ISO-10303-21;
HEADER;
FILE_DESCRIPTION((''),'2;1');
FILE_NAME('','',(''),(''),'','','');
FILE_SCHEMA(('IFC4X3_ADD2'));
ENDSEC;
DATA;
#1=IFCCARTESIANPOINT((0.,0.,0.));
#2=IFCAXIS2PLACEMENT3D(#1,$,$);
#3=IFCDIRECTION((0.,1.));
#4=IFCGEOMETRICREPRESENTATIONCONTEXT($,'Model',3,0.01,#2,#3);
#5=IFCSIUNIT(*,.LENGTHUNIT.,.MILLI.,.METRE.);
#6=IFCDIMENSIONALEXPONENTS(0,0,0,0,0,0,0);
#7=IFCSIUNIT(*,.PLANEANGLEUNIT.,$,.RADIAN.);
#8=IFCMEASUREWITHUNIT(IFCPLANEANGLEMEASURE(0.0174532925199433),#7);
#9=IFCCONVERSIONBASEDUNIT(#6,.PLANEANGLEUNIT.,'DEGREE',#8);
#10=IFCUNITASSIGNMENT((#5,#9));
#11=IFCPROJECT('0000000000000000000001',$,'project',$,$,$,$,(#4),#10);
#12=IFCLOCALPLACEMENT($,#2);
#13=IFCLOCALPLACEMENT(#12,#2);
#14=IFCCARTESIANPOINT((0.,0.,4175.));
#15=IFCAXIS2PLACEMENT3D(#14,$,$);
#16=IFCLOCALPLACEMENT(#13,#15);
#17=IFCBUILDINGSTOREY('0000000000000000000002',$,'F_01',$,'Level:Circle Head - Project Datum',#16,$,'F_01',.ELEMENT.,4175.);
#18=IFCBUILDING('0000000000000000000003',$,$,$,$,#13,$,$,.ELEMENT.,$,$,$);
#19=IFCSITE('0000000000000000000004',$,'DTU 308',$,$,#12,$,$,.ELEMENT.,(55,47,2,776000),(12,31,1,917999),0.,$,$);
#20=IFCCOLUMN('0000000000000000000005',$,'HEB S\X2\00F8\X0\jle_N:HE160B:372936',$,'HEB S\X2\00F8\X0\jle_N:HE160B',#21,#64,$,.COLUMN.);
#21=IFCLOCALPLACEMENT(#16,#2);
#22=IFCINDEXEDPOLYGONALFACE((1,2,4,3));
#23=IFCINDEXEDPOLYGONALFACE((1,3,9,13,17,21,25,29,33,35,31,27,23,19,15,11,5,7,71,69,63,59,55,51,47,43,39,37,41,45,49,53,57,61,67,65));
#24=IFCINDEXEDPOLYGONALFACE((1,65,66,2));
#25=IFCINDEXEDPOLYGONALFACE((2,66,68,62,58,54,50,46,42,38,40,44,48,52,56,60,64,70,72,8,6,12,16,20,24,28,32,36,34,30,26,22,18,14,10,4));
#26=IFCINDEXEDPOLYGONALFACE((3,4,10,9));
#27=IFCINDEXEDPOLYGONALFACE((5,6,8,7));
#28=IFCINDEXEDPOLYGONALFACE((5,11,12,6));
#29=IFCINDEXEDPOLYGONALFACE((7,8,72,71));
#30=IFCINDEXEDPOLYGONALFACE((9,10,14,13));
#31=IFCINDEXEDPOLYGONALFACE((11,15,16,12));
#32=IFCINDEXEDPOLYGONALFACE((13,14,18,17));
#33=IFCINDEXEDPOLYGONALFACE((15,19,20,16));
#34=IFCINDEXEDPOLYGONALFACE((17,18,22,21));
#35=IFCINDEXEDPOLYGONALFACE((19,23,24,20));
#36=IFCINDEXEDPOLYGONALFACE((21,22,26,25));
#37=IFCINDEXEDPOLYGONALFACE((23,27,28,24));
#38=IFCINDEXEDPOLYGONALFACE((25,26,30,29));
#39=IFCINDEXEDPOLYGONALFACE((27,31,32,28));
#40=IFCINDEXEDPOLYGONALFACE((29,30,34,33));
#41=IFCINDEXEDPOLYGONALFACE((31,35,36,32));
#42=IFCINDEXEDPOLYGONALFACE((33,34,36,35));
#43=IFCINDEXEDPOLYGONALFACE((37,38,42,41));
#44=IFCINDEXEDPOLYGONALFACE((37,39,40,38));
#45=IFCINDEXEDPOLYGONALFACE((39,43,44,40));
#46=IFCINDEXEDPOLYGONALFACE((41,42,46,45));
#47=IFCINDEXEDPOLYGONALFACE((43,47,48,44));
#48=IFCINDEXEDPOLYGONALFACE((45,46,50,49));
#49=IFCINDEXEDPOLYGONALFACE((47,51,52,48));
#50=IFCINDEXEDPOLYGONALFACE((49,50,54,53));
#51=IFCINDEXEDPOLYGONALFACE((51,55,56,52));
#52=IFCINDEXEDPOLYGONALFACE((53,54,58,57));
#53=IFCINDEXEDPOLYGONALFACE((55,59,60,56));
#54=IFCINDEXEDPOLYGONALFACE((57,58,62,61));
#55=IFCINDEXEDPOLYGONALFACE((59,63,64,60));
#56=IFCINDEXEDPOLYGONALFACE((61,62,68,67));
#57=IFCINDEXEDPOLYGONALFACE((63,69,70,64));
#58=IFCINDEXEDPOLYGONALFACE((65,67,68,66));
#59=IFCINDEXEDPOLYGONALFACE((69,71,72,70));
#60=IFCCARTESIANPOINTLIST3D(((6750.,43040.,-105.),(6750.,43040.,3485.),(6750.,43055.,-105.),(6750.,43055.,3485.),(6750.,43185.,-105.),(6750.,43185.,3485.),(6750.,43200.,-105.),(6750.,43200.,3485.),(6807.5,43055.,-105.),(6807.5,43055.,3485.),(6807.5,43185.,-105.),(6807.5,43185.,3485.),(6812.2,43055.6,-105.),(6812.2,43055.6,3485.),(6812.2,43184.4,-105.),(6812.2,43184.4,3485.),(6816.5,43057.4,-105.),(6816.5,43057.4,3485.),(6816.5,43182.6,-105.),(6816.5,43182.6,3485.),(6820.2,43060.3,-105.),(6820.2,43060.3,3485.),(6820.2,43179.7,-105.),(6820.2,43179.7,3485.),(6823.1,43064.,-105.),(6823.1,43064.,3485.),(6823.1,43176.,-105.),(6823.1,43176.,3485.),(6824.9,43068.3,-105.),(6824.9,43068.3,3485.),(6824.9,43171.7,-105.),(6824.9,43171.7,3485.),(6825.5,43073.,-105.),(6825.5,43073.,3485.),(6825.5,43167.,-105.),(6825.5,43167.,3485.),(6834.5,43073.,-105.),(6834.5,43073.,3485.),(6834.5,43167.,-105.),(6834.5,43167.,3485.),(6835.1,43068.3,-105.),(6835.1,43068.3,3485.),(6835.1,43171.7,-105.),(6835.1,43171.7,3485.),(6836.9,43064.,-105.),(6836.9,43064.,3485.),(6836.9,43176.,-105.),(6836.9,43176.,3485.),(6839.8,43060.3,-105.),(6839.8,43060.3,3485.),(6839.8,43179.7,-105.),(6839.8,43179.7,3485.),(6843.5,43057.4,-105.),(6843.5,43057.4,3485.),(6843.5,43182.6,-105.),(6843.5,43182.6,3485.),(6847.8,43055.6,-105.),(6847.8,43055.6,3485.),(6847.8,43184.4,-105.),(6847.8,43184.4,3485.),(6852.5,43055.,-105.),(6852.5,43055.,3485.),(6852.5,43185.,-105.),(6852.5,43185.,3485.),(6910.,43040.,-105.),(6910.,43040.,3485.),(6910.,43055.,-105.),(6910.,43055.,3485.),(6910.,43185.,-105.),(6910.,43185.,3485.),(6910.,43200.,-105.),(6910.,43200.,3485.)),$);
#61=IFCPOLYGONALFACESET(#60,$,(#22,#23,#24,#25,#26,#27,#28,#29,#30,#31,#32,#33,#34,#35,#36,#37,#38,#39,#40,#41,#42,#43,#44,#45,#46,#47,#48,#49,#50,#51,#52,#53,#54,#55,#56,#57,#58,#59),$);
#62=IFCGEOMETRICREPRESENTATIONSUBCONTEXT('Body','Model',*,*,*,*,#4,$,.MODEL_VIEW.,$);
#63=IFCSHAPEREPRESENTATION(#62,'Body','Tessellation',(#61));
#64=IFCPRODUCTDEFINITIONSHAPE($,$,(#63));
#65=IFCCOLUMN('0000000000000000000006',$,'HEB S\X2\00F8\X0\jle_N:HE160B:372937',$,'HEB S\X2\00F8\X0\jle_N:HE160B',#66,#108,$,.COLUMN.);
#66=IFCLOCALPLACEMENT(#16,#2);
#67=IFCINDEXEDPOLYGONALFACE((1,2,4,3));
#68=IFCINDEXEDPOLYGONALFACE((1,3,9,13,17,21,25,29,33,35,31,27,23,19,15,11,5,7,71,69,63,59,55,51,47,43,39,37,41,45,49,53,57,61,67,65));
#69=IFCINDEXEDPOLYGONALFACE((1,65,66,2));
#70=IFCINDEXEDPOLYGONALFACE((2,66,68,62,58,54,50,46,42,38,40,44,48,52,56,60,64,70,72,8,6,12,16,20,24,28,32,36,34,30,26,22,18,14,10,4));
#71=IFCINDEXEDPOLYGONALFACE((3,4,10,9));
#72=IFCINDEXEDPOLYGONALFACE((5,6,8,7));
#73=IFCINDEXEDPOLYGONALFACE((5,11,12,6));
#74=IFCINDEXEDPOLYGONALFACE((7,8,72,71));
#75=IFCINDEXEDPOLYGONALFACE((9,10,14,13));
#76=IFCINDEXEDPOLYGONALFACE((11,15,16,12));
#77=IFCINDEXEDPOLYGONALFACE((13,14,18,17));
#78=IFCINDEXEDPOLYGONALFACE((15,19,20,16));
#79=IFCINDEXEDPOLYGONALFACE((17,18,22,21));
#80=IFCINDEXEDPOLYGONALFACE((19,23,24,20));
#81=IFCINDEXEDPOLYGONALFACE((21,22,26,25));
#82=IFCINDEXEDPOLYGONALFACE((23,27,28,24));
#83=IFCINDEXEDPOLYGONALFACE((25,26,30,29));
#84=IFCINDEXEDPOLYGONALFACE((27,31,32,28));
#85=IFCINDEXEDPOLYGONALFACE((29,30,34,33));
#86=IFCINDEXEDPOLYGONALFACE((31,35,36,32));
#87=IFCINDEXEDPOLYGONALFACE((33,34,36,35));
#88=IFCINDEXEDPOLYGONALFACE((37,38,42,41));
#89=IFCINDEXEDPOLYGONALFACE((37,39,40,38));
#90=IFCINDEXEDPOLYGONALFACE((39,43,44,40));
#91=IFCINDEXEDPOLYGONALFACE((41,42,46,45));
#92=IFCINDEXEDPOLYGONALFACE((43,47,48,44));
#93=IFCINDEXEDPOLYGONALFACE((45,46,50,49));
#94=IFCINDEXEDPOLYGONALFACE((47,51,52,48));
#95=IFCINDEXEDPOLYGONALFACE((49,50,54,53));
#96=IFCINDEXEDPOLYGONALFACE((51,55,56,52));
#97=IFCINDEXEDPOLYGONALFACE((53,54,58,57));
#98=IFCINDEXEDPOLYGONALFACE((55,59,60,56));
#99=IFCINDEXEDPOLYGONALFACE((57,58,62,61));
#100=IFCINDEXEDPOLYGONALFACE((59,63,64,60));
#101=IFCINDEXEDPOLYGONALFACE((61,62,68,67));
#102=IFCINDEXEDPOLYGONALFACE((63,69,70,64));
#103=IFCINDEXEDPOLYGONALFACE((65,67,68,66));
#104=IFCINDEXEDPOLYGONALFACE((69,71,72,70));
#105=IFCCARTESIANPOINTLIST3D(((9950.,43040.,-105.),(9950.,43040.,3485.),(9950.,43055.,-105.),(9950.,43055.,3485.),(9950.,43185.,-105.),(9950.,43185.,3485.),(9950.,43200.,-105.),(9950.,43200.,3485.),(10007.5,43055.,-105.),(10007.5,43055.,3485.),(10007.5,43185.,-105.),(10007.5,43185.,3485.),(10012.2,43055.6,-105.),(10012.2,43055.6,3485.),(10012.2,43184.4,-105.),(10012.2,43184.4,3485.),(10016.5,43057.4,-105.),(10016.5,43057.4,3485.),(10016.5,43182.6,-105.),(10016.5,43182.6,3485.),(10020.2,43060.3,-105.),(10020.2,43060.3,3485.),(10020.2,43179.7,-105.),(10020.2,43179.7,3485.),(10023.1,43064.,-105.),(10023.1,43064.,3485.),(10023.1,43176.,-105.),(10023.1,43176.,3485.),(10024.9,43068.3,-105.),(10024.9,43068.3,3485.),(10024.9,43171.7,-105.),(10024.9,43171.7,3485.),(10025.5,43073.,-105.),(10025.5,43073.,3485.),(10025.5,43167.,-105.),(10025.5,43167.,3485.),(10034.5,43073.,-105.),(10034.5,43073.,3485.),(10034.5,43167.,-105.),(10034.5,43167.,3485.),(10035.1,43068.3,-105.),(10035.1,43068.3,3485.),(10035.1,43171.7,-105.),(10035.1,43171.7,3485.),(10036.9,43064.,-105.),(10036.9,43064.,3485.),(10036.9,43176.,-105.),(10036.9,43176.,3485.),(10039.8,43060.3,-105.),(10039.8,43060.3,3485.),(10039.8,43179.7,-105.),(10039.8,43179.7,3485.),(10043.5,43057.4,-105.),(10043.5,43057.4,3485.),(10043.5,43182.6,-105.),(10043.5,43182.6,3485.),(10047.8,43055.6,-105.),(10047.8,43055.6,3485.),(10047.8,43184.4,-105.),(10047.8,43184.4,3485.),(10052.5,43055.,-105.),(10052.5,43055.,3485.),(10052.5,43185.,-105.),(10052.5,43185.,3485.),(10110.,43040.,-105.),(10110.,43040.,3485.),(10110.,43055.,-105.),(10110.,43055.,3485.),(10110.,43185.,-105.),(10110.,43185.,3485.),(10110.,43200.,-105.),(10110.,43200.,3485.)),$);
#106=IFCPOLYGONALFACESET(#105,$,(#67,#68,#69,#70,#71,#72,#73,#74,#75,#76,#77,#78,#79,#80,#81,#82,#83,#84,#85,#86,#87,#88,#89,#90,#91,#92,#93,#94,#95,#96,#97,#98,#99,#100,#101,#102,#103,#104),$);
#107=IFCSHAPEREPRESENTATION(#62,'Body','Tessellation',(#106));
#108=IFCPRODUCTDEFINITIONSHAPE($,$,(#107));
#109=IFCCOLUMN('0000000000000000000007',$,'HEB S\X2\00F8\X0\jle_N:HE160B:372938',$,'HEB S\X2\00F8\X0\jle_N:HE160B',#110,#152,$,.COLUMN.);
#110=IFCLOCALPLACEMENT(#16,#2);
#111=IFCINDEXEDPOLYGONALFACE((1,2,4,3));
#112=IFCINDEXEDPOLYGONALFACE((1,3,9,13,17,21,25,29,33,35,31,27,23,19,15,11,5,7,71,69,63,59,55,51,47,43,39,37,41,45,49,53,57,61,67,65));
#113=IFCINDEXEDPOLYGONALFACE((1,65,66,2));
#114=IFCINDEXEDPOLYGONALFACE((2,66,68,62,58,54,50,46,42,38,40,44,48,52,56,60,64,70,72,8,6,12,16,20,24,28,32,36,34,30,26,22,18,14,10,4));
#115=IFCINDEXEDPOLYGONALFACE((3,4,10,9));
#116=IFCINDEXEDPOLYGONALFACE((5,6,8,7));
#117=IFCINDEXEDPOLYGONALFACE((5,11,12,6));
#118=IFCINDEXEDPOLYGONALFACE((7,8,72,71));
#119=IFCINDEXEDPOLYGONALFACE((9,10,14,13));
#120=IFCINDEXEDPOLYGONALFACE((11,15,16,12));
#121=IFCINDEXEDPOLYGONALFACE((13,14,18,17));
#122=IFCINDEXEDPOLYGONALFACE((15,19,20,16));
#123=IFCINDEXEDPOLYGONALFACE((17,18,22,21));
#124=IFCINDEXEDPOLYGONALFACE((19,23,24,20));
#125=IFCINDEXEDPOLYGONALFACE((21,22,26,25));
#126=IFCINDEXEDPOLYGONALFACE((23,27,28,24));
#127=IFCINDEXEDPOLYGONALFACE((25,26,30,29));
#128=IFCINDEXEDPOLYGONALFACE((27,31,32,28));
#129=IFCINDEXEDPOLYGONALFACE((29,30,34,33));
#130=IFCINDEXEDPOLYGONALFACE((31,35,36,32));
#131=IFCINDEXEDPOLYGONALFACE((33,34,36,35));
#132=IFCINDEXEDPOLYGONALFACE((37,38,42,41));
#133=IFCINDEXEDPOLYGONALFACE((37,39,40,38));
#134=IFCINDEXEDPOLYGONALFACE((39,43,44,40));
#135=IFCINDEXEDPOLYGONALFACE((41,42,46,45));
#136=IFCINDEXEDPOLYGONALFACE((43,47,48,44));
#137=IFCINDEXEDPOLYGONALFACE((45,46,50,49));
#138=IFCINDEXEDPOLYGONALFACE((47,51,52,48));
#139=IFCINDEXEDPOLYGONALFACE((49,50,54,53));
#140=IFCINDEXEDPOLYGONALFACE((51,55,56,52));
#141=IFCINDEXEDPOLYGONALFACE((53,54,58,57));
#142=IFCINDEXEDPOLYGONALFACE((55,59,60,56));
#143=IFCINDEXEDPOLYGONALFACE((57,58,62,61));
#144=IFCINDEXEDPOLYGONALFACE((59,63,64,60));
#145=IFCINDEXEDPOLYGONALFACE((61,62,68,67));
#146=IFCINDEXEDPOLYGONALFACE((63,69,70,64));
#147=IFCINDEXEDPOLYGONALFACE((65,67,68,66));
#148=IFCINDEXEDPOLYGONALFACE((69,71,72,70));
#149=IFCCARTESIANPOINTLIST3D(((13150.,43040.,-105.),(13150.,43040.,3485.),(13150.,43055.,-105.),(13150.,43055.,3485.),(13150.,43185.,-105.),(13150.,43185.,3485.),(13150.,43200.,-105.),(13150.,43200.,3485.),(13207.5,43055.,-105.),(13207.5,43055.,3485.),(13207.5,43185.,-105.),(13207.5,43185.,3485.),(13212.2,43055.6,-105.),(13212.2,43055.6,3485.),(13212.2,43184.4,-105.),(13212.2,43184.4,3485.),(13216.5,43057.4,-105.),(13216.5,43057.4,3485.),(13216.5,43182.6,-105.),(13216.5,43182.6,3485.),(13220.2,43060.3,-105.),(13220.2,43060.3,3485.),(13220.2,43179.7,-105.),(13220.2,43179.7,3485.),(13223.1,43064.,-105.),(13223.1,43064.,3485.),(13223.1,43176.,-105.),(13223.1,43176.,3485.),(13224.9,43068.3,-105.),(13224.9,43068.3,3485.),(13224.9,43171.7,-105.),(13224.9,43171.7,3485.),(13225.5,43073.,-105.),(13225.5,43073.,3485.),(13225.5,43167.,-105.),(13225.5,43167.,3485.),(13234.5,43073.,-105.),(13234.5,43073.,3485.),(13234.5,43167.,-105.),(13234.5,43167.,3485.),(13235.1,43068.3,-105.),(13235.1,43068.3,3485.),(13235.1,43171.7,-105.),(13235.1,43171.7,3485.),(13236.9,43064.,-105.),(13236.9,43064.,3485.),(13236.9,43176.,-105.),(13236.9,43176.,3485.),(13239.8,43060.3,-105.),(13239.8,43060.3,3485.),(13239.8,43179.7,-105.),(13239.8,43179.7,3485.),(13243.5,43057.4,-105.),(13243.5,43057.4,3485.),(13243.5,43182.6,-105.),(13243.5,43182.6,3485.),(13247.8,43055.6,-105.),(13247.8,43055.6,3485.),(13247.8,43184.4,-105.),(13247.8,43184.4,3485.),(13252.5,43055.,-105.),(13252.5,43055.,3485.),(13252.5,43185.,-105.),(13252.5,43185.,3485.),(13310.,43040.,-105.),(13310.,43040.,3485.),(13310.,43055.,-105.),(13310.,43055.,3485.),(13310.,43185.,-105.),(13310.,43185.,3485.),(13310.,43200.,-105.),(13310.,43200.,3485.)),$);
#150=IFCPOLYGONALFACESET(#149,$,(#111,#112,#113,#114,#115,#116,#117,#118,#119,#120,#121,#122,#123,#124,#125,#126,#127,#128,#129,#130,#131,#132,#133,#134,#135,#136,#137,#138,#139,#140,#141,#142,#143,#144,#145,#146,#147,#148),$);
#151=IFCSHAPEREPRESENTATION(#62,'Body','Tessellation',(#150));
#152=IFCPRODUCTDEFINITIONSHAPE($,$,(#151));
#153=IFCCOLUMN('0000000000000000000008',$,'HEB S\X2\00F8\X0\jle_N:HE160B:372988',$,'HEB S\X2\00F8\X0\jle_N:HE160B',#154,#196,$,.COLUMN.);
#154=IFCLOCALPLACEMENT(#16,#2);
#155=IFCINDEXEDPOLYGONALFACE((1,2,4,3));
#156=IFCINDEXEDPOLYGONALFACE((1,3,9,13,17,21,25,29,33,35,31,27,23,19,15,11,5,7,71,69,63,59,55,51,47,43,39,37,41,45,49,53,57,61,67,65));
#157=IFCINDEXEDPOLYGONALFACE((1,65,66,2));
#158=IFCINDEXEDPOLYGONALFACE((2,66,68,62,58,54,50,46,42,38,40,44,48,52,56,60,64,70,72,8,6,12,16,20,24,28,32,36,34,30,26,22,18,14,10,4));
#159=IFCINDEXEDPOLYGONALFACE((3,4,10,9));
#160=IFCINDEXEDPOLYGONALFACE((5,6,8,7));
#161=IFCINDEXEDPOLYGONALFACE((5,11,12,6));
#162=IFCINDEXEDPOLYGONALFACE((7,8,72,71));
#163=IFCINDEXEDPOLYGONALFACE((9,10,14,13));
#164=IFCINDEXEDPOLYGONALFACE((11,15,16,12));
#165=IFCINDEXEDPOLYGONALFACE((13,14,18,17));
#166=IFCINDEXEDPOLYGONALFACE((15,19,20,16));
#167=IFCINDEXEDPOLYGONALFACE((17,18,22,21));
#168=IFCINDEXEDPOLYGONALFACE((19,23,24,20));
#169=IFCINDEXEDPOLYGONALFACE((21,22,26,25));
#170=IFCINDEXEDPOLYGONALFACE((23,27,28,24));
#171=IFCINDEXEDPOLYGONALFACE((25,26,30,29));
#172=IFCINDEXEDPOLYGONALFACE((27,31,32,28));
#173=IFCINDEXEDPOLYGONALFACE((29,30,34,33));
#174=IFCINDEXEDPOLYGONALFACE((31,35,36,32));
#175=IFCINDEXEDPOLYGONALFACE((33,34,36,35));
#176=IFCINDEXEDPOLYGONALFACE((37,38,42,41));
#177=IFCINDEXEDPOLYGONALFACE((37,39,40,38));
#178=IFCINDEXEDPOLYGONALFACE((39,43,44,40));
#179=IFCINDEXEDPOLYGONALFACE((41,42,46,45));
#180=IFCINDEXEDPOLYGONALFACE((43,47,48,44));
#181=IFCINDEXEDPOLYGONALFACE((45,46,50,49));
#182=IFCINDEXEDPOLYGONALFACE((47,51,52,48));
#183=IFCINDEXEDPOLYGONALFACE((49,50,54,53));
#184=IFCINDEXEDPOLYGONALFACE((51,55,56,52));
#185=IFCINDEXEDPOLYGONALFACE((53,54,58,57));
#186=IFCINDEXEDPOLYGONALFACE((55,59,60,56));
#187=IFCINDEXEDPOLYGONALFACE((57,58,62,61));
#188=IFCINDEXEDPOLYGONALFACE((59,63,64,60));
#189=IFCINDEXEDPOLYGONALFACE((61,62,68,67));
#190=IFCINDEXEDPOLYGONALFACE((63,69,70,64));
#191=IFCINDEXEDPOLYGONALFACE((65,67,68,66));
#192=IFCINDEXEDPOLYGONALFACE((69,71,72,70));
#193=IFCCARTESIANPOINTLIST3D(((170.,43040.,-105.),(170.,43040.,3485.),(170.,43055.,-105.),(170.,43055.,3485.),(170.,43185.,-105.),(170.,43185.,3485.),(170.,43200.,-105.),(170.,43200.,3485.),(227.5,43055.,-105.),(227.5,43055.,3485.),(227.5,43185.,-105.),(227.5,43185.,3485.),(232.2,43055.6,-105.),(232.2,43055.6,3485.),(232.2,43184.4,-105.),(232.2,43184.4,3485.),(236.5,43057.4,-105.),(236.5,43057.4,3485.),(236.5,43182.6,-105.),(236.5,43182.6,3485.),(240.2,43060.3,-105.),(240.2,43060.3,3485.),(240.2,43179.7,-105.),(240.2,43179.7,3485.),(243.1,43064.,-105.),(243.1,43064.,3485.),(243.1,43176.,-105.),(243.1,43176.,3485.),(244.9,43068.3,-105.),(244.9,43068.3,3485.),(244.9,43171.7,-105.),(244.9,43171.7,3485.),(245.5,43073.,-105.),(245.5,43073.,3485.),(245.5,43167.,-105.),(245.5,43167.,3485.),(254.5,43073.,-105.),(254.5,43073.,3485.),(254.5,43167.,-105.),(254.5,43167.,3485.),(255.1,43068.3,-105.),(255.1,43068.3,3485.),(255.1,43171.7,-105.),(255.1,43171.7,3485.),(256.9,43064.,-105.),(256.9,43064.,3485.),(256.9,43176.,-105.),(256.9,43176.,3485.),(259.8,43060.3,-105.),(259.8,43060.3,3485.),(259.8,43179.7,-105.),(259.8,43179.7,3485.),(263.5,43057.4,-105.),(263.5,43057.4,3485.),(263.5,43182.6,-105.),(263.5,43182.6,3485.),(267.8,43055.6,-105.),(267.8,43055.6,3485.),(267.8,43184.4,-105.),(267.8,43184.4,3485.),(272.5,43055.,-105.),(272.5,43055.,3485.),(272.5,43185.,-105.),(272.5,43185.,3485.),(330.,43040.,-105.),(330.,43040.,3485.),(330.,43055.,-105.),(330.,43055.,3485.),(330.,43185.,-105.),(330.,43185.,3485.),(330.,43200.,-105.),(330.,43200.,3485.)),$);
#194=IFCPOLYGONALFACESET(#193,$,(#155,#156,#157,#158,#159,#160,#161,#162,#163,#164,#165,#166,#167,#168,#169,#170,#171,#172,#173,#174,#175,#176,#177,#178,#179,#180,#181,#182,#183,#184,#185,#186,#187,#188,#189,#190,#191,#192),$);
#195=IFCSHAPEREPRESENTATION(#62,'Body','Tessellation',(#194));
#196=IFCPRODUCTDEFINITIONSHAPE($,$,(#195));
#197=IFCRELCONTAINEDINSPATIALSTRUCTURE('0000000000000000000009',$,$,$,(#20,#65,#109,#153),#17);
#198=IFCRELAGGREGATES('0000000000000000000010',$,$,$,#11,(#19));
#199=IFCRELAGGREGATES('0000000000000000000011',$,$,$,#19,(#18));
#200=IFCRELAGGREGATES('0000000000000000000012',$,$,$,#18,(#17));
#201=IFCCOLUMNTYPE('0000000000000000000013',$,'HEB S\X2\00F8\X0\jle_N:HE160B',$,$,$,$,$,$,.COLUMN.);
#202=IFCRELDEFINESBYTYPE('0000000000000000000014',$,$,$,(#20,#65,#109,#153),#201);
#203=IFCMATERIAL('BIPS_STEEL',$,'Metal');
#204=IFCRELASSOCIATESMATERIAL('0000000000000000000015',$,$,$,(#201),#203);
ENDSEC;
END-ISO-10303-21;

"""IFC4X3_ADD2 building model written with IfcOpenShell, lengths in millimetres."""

from ifc_helpers import new_model, entity, si_unit, converted_unit, direction, frame, frame_2d, origin, place, context, subcontext, project, spatial, i_section, extrude, source, transform, mapped, material, material_profile, profile_set, type_object, element, save


model = new_model("IFC4X3_ADD2")

# Units and contexts
model_context = context("Model", 3, precision=0.01, world=origin(), true_north=direction((0.0, 1.0)))
body_context = subcontext(model_context, "Body", "Model", "MODEL_VIEW")
ifc_project = project(units=[si_unit("LENGTHUNIT", "METRE", prefix="MILLI"), converted_unit("PLANEANGLEUNIT", "DEGREE", entity("IfcPlaneAngleMeasure", 0.0174532925199433), si_unit("PLANEANGLEUNIT", "RADIAN"), dimensions=[0, 0, 0, 0, 0, 0, 0])], contexts=[model_context])

# Site, building, storey
site_placement = place(None, origin())
site = spatial("IfcSite", under=ifc_project, at=site_placement, Name="DTU 308", CompositionType="ELEMENT", RefLatitude=(55, 47, 2, 776000), RefLongitude=(12, 31, 1, 917999), RefElevation=0.0)
building_placement = place(site_placement, origin())
building = spatial("IfcBuilding", under=site, at=building_placement, CompositionType="ELEMENT")
storey_placement = place(building_placement, frame((0.0, 0.0, 4175.0)))
storey = spatial("IfcBuildingStorey", under=building, at=storey_placement, Name="F_01", ObjectType="Level:Circle Head - Project Datum", LongName="F_01", CompositionType="ELEMENT", Elevation=4175.0)

# Columns
ifc_material_1 = material(Name="BIPS_STEEL", Category="Metal")
ifc_material_profile_1 = material_profile(ifc_material_1, i_section(OverallWidth=160.0, OverallDepth=160.0, WebThickness=9.0, FlangeThickness=15.0, FilletRadius=18.0, at=frame_2d((0.0, 0.0), x_axis=(1.0, 0.0))), Name="HE160B")
ifc_profile_set_1 = profile_set([ifc_material_profile_1], Name="HE160B")
column_type_1 = type_object("IfcColumnType", Name="HEB Søjle_N:HE160B", PredefinedType="COLUMN", material=ifc_profile_set_1)
shared_shape_1 = source(origin(), body_context, "Body", "SweptSolid", [
    extrude(i_section(OverallWidth=160.0, OverallDepth=160.0, WebThickness=9.0, FlangeThickness=15.0, FilletRadius=18.0, at=frame_2d((0.0, 0.0), x_axis=(1.0, 0.0))), frame((0.0, 0.0, 4070.0), z_axis=(0.0, 0.0, 1.0), x_axis=(-1.0, 0.0, 0.0)), (0.0, 0.0, 1.0), 3590.0),
])
for number, where, name in (
    (1, (6830.0, 43120.0, -4175.0), "HEB Søjle_N:HE160B:372936"),
    (2, (10030.0, 43120.0, -4175.0), "HEB Søjle_N:HE160B:372937"),
    (3, (13230.0, 43120.0, -4175.0), "HEB Søjle_N:HE160B:372938"),
    (4, (250.0, 43120.0, -4175.0), "HEB Søjle_N:HE160B:372988"),
):
    element("IfcColumn", number, at=place(storey_placement, frame(where)), inside=storey, type_object=column_type_1, Name=name, ObjectType="HEB Søjle_N:HE160B", PredefinedType="COLUMN", context=body_context, shape_type="MappedRepresentation", body=[
        mapped(shared_shape_1, transform((0.0, 0.0, 0.0), scale=1.0)),
    ])

save(model, "model.ifc")
